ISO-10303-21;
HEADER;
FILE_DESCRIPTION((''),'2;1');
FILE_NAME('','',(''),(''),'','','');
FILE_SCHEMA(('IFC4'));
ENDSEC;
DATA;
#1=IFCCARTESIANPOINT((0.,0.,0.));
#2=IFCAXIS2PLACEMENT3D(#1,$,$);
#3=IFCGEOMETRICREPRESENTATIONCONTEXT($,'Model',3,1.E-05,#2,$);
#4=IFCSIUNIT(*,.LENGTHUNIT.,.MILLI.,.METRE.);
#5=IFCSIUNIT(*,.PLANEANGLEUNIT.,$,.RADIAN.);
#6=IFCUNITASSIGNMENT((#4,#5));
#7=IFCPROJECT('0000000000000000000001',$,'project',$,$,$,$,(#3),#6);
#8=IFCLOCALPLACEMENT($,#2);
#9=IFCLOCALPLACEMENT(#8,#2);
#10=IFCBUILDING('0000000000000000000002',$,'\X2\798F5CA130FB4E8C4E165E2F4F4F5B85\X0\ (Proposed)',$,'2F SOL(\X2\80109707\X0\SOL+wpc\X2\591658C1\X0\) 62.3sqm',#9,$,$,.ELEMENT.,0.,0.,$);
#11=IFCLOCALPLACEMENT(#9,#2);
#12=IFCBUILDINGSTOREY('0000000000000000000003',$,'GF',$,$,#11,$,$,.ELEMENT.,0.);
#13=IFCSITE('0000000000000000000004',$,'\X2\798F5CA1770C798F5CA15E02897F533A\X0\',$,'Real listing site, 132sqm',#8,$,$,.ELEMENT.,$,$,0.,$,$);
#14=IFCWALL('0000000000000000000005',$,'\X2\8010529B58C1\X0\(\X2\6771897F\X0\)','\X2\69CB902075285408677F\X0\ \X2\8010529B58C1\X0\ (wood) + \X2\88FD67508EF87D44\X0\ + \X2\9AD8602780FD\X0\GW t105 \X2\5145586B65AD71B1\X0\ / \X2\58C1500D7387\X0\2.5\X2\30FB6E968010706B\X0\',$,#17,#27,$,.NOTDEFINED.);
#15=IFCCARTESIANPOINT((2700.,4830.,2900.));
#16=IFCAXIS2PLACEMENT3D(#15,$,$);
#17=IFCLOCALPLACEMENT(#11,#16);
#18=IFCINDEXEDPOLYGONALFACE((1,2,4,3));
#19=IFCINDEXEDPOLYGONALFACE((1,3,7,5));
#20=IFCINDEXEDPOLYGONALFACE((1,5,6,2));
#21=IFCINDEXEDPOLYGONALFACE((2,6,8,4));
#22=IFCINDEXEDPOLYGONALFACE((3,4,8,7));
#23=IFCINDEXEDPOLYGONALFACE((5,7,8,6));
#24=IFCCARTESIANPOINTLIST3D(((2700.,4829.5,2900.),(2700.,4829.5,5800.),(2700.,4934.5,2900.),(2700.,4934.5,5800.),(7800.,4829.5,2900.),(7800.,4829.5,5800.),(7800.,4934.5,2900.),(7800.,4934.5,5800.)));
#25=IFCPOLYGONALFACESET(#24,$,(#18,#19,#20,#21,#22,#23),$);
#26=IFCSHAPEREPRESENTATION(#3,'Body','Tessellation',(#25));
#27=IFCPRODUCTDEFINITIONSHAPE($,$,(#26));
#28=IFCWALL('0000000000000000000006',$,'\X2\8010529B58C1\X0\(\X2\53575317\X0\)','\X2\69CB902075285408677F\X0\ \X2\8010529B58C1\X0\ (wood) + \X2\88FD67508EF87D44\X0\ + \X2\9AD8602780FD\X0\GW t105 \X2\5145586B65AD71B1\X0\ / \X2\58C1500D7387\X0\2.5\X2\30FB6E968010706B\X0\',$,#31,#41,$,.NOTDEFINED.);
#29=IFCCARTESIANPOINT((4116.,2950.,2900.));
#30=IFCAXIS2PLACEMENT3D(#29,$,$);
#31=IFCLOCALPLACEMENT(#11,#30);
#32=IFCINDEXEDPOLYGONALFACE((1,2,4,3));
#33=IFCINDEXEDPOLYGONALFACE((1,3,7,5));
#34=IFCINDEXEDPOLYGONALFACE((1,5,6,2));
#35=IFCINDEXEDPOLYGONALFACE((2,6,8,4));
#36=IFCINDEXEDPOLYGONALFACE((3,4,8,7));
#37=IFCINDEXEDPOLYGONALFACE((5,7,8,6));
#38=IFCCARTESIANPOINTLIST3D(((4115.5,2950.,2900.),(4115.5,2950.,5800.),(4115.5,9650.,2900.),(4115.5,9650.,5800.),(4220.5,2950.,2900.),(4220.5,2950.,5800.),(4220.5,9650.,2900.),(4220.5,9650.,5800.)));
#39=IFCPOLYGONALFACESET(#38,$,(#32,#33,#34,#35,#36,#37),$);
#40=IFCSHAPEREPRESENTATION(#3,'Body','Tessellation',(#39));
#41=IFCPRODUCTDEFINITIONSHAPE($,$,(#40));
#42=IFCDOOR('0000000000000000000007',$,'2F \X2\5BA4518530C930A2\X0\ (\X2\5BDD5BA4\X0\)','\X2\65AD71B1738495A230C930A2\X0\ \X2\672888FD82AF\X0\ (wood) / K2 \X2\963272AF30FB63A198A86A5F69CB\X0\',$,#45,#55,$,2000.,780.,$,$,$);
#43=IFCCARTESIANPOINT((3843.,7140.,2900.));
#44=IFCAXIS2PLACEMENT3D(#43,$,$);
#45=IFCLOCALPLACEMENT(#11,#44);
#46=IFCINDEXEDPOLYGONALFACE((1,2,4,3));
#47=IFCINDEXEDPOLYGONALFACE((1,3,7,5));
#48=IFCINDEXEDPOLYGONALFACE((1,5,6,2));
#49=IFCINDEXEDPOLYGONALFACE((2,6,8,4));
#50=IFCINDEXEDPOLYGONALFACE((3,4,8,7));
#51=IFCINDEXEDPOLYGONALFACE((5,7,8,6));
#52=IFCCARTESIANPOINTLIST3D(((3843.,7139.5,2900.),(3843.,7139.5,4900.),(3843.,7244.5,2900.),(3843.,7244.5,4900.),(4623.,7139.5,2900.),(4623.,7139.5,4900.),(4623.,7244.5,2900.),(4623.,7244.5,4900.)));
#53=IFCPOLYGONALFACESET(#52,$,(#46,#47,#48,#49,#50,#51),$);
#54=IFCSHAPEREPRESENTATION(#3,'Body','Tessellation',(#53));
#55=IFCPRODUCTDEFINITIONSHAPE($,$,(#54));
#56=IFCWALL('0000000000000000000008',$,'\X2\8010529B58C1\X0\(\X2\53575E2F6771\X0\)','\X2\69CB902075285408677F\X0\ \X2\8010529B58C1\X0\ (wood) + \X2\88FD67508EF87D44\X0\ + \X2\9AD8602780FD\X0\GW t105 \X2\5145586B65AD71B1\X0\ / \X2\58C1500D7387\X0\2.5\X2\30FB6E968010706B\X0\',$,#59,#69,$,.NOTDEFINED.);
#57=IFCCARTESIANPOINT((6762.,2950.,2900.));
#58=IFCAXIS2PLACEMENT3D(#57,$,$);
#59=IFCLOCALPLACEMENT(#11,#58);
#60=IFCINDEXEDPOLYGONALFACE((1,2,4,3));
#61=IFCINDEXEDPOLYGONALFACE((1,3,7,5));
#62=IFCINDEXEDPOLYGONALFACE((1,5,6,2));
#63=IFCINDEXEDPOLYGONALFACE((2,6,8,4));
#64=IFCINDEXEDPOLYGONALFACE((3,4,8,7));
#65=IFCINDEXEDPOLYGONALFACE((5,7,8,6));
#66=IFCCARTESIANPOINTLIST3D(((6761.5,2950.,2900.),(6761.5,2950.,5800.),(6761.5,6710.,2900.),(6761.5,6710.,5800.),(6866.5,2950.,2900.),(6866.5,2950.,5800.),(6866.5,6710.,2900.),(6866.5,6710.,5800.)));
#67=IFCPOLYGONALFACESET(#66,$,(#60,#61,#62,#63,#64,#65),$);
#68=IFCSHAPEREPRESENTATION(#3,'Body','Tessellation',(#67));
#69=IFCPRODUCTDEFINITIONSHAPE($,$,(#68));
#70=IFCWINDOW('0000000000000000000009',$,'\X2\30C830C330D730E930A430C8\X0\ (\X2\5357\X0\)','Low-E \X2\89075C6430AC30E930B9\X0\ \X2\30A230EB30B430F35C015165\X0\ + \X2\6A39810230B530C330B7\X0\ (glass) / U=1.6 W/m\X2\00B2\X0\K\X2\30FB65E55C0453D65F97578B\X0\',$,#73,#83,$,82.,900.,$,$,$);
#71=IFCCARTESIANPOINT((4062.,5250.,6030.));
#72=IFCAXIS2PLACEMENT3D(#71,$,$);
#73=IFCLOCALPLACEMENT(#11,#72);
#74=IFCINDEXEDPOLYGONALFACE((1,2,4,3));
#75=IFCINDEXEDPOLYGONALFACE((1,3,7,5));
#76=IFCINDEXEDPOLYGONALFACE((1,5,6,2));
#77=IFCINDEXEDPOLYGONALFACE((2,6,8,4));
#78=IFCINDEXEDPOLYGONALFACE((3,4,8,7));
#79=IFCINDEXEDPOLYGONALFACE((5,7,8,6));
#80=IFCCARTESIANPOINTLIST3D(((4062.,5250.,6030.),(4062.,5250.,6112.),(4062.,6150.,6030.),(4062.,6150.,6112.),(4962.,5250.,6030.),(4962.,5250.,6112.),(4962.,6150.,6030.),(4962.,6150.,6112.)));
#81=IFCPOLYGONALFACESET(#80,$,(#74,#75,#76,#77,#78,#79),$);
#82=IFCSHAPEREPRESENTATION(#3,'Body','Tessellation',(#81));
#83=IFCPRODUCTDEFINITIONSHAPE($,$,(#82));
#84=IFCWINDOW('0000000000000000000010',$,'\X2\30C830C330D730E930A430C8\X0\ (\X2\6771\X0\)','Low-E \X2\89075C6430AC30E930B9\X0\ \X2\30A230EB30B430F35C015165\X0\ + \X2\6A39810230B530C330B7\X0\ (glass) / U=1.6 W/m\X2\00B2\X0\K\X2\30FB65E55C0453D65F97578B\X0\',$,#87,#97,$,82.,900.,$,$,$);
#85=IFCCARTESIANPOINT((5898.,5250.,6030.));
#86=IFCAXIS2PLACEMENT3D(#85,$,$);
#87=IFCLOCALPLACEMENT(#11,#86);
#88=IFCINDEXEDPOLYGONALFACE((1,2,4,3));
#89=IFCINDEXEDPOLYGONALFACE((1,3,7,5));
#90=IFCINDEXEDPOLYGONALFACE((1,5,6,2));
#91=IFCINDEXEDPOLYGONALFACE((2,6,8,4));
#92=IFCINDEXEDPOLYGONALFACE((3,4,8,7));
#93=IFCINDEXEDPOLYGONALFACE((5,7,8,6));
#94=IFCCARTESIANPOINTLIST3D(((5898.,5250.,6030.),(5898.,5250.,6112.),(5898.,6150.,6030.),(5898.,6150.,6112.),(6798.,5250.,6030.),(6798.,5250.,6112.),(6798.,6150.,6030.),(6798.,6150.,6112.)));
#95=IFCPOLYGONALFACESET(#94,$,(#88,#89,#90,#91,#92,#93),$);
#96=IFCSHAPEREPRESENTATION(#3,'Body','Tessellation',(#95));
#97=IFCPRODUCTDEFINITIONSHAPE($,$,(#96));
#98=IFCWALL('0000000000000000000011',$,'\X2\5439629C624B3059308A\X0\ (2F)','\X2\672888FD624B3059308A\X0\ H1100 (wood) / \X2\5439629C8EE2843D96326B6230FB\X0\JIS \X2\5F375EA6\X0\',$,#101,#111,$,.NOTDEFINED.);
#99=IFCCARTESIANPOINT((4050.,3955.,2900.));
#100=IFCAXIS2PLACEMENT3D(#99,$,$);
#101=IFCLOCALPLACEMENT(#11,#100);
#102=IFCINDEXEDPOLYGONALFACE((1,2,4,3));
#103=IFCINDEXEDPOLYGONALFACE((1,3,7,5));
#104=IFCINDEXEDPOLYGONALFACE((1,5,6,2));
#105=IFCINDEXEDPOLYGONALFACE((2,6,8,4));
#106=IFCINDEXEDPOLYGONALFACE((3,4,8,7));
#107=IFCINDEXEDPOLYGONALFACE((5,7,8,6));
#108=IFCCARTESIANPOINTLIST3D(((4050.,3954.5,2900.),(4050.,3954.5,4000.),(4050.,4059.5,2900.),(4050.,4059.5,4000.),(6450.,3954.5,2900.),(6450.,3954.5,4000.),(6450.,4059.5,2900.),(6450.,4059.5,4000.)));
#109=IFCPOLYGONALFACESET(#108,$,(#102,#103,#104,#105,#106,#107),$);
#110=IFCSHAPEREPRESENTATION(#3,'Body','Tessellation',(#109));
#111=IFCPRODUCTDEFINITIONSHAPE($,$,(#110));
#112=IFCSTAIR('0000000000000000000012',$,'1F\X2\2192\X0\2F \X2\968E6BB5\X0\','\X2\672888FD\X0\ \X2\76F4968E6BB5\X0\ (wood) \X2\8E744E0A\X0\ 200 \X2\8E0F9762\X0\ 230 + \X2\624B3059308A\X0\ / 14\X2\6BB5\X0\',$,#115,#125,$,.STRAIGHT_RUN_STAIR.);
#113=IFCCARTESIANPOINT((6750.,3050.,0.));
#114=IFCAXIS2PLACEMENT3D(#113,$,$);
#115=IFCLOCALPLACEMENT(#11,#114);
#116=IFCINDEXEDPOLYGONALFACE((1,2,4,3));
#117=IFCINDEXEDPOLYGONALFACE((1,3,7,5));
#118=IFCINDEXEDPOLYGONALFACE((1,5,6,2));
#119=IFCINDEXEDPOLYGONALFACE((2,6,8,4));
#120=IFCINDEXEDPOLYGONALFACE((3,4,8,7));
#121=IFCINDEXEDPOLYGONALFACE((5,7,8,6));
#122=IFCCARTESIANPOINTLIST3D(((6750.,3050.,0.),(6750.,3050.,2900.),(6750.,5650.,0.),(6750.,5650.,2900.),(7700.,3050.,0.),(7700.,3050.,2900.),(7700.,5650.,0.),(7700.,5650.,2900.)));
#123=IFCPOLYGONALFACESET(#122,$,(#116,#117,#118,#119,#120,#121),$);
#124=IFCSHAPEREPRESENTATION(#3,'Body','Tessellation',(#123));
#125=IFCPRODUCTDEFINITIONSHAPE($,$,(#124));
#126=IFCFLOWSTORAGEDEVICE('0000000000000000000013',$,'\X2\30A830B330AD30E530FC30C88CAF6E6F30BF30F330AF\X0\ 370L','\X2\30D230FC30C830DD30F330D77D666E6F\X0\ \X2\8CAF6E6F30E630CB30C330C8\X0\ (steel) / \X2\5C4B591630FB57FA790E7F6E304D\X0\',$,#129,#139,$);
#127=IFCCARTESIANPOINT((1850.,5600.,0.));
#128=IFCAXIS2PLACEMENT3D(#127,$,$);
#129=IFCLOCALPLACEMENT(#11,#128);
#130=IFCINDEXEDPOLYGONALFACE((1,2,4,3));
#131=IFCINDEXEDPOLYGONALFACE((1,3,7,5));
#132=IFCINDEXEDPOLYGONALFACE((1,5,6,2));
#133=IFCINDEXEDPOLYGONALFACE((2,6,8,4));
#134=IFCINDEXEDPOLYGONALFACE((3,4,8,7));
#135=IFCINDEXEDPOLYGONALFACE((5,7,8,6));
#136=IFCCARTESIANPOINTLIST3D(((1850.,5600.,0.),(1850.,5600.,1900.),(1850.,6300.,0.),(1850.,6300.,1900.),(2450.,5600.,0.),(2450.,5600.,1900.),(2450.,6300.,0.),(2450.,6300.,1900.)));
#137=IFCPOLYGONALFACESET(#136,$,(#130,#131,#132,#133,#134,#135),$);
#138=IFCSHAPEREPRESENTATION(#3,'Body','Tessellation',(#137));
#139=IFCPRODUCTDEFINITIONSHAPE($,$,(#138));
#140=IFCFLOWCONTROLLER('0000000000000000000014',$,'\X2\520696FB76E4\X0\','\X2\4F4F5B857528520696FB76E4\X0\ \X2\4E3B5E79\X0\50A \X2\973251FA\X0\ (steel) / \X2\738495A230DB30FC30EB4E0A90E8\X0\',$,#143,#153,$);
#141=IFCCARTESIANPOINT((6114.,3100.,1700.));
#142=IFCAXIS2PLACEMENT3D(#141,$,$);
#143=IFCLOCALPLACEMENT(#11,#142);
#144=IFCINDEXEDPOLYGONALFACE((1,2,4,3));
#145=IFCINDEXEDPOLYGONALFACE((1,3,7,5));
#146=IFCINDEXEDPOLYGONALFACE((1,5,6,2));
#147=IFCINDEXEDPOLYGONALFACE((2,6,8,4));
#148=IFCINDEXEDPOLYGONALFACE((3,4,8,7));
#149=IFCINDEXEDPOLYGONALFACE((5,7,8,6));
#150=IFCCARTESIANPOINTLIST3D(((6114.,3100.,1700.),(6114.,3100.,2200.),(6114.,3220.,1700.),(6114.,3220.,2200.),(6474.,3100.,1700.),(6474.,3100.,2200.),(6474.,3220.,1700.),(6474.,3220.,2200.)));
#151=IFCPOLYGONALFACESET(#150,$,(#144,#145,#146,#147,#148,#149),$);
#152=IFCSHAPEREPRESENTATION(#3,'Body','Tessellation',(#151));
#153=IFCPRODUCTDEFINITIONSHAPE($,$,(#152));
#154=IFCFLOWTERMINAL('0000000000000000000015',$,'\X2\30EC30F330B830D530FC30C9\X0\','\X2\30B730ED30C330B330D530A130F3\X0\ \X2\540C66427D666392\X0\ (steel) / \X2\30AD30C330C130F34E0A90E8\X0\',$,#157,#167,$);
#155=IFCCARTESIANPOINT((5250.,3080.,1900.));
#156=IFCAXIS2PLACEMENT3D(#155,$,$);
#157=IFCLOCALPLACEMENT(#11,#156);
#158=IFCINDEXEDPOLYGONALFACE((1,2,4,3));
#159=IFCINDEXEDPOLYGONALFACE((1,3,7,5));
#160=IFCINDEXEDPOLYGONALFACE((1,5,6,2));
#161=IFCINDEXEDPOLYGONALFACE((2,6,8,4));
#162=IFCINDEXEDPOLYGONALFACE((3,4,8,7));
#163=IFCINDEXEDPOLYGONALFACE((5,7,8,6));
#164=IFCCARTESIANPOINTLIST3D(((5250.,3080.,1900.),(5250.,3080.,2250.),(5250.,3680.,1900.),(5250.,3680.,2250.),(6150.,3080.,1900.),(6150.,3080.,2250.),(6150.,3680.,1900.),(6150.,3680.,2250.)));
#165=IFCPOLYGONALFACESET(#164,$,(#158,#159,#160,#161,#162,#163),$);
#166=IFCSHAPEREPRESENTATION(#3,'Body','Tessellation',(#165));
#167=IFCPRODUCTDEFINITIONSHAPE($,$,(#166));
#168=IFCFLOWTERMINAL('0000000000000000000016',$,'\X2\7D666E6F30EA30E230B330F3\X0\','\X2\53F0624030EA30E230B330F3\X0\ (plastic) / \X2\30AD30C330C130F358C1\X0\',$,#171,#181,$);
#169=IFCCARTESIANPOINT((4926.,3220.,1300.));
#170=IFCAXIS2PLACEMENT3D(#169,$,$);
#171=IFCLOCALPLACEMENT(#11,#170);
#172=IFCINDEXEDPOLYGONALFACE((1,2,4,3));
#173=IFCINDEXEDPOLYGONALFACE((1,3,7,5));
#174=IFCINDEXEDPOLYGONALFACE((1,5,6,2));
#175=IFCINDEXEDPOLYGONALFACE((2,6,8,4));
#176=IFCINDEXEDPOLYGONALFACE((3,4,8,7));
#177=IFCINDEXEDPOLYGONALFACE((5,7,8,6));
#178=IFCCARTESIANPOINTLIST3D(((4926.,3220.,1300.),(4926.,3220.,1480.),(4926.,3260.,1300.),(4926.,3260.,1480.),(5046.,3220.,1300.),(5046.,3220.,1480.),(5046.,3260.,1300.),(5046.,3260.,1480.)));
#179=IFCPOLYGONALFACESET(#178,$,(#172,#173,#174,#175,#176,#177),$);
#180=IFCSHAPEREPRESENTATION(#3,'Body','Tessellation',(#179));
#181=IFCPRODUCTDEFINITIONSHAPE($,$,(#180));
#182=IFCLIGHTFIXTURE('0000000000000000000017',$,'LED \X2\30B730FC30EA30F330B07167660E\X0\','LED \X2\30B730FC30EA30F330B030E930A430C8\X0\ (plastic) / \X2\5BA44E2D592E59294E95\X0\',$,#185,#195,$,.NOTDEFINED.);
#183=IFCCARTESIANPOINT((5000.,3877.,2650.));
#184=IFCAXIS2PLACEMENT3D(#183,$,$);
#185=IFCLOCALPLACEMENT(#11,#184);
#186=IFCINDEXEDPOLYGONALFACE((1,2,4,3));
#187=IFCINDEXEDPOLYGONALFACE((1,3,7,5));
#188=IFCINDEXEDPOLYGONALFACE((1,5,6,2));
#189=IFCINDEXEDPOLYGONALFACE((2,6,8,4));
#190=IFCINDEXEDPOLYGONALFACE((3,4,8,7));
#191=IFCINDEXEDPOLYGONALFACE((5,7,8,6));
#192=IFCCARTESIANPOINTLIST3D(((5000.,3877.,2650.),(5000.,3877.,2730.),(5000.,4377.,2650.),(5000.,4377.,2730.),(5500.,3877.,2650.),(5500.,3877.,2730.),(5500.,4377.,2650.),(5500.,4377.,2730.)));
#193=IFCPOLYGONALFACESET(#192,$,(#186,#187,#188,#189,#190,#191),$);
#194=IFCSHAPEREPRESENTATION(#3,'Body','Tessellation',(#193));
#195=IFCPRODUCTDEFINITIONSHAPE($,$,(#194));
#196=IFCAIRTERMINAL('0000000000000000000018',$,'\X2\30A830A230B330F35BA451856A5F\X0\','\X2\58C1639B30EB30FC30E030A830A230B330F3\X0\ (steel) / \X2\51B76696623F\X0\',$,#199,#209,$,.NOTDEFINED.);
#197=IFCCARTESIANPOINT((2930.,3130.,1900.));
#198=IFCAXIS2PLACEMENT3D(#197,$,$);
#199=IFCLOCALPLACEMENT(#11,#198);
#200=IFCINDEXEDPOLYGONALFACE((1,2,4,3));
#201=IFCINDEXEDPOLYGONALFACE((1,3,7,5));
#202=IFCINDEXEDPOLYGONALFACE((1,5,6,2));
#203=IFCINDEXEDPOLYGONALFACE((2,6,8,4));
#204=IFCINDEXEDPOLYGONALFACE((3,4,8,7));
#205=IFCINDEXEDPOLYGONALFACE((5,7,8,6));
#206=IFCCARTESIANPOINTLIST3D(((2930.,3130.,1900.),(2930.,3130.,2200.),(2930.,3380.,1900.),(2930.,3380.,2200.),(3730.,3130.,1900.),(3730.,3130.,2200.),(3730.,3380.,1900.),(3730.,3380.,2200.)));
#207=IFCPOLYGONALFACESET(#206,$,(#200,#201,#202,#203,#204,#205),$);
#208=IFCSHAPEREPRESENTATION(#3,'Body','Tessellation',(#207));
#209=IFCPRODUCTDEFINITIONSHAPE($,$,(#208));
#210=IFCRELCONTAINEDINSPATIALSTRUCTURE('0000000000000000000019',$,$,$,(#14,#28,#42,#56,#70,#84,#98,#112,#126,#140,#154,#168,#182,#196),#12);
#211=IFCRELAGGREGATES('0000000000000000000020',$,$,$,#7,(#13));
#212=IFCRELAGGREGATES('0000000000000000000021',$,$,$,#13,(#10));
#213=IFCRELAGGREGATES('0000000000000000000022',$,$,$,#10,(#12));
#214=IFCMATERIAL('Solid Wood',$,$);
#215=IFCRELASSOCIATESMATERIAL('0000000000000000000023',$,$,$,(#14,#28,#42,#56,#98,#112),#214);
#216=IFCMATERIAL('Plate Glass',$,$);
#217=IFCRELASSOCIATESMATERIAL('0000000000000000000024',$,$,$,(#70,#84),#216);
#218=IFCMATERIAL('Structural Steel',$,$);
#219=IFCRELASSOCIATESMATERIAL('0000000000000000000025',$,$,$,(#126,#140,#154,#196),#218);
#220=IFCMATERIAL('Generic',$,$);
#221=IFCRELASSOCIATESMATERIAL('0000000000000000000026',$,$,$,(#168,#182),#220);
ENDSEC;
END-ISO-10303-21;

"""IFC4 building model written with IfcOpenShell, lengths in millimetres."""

from ifc_helpers import new_model, si_unit, frame, frame_2d, origin, place, context, project, spatial, rectangle, extrude, material, element, fill, save


model = new_model("IFC4")

# Units and contexts
model_context = context("Model", 3, precision=1e-05, world=origin())
ifc_project = project(units=[si_unit("LENGTHUNIT", "METRE", prefix="MILLI"), si_unit("PLANEANGLEUNIT", "RADIAN")], contexts=[model_context])

# Site, building, storey
site_placement = place(None, origin())
site = spatial("IfcSite", under=ifc_project, at=site_placement, Name="福岡県福岡市西区", ObjectType="Real listing site, 132sqm", CompositionType="ELEMENT", RefElevation=0.0)
building_placement = place(site_placement, origin())
building = spatial("IfcBuilding", under=site, at=building_placement, Name="福岡・二世帯住宅 (Proposed)", ObjectType="2F SOL(耐震SOL+wpc外壁) 62.3sqm", CompositionType="ELEMENT", ElevationOfRefHeight=0.0, ElevationOfTerrain=0.0)
storey_placement = place(building_placement, origin())
storey = spatial("IfcBuildingStorey", under=building, at=storey_placement, Name="GF", CompositionType="ELEMENT", Elevation=0.0)

# Shared definitions
ifc_material_1 = material(Name="Solid Wood")

# Wall
wall_1_placement = place(storey_placement, frame((2700.0, 4830.0, 2900.0)))
element("IfcWall", 1, at=wall_1_placement, inside=storey, material=ifc_material_1, Name="耐力壁(東西)", Description="構造用合板 耐力壁 (wood) + 製材軸組 + 高性能GW t105 充填断熱 / 壁倍率2.5・準耐火", PredefinedType="NOTDEFINED", context=model_context, shape_type="SweptSolid", body=[
    extrude(rectangle(XDim=5100.0, YDim=105.0, at=frame_2d((2550.0, 52.0))), frame((2700.0, 4830.0, 2900.0)), (0.0, 0.0, 1.0), 2900.0),
])

# Wall, opening, door
wall_2_placement = place(storey_placement, frame((4116.0, 2950.0, 2900.0)))
wall_2 = element("IfcWall", 2, at=wall_2_placement, inside=storey, material=ifc_material_1, Name="耐力壁(南北)", Description="構造用合板 耐力壁 (wood) + 製材軸組 + 高性能GW t105 充填断熱 / 壁倍率2.5・準耐火", PredefinedType="NOTDEFINED", context=model_context, shape_type="SweptSolid", body=[
    extrude(rectangle(XDim=105.0, YDim=6700.0, at=frame_2d((52.0, 3350.0))), frame((4116.0, 2950.0, 2900.0)), (0.0, 0.0, 1.0), 2900.0),
])
opening_placement = place(storey_placement, frame((3843.0, 7140.0, 2900.0)))
opening = element("IfcOpeningElement", 3, at=opening_placement, cuts=wall_2, PredefinedType="NOTDEFINED", context=model_context, shape_type="SweptSolid", body=[
    extrude(rectangle(XDim=780.0, YDim=105.0, at=frame_2d((390.0, 52.0))), frame((3843.0, 7140.0, 2900.0)), (0.0, 0.0, 1.0), 2000.0),
])
door_placement = place(storey_placement, frame((3843.0, 7140.0, 2900.0)))
door = element("IfcDoor", 4, at=door_placement, inside=storey, material=ifc_material_1, Name="2F 室内ドア (寝室)", Description="断熱玄関ドア 木製芯 (wood) / K2 防犯・採風機構", OverallHeight=2000.0, OverallWidth=780.0, context=model_context, shape_type="SweptSolid", body=[
    extrude(rectangle(XDim=780.0, YDim=105.0, at=frame_2d((390.0, 52.0))), frame((3843.0, 7140.0, 2900.0)), (0.0, 0.0, 1.0), 2000.0),
])
fill(opening, door)

# Wall
wall_3_placement = place(storey_placement, frame((6762.0, 2950.0, 2900.0)))
element("IfcWall", 5, at=wall_3_placement, inside=storey, material=ifc_material_1, Name="耐力壁(南帯東)", Description="構造用合板 耐力壁 (wood) + 製材軸組 + 高性能GW t105 充填断熱 / 壁倍率2.5・準耐火", PredefinedType="NOTDEFINED", context=model_context, shape_type="SweptSolid", body=[
    extrude(rectangle(XDim=105.0, YDim=3760.0, at=frame_2d((52.0, 1880.0))), frame((6762.0, 2950.0, 2900.0)), (0.0, 0.0, 1.0), 2900.0),
])

# Windows
ifc_material_2 = material(Name="Plate Glass")
window_1_placement = place(storey_placement, frame((4062.0, 5250.0, 6030.0)))
element("IfcWindow", 6, at=window_1_placement, inside=storey, material=ifc_material_2, Name="トップライト (南)", Description="Low-E 複層ガラス アルゴン封入 + 樹脂サッシ (glass) / U=1.6 W/m²K・日射取得型", OverallHeight=82.0, OverallWidth=900.0, context=model_context, shape_type="SweptSolid", body=[
    extrude(rectangle(XDim=900.0, YDim=900.0, at=frame_2d((450.0, 450.0))), frame((4062.0, 5250.0, 6030.0)), (0.0, 0.0, 1.0), 82.0),
])
window_2_placement = place(storey_placement, frame((5898.0, 5250.0, 6030.0)))
element("IfcWindow", 7, at=window_2_placement, inside=storey, material=ifc_material_2, Name="トップライト (東)", Description="Low-E 複層ガラス アルゴン封入 + 樹脂サッシ (glass) / U=1.6 W/m²K・日射取得型", OverallHeight=82.0, OverallWidth=900.0, context=model_context, shape_type="SweptSolid", body=[
    extrude(rectangle(XDim=900.0, YDim=900.0, at=frame_2d((450.0, 450.0))), frame((5898.0, 5250.0, 6030.0)), (0.0, 0.0, 1.0), 82.0),
])

# Wall
wall_4_placement = place(storey_placement, frame((4050.0, 3955.0, 2900.0)))
element("IfcWall", 8, at=wall_4_placement, inside=storey, material=ifc_material_1, Name="吹抜手すり (2F)", Description="木製手すり H1100 (wood) / 吹抜転落防止・JIS 強度", PredefinedType="NOTDEFINED", context=model_context, shape_type="SweptSolid", body=[
    extrude(rectangle(XDim=2400.0, YDim=105.0, at=frame_2d((1200.0, 52.0))), frame((4050.0, 3955.0, 2900.0)), (0.0, 0.0, 1.0), 1100.0),
])

# Stair
stair_placement = place(storey_placement, frame((6750.0, 3050.0, 0.0)))
element("IfcStair", 9, at=stair_placement, inside=storey, material=ifc_material_1, Name="1F→2F 階段", Description="木製 直階段 (wood) 蹴上 200 踏面 230 + 手すり / 14段", PredefinedType="STRAIGHT_RUN_STAIR", context=model_context, shape_type="SweptSolid", body=[
    extrude(rectangle(XDim=950.0, YDim=2600.0, at=frame_2d((475.0, 1300.0))), frame((6750.0, 3050.0, 0.0)), (0.0, 0.0, 1.0), 2900.0),
])

# Flow storage device
ifc_material_3 = material(Name="Structural Steel")
flow_storage_device_placement = place(storey_placement, frame((1850.0, 5600.0, 0.0)))
element("IfcFlowStorageDevice", 10, at=flow_storage_device_placement, inside=storey, material=ifc_material_3, Name="エコキュート貯湯タンク 370L", Description="ヒートポンプ給湯 貯湯ユニット (steel) / 屋外・基礎置き", context=model_context, shape_type="SweptSolid", body=[
    extrude(rectangle(XDim=600.0, YDim=700.0, at=frame_2d((300.0, 350.0))), frame((1850.0, 5600.0, 0.0)), (0.0, 0.0, 1.0), 1900.0),
])

# Flow controller
flow_controller_placement = place(storey_placement, frame((6114.0, 3100.0, 1700.0)))
element("IfcFlowController", 11, at=flow_controller_placement, inside=storey, material=ifc_material_3, Name="分電盤", Description="住宅用分電盤 主幹50A 露出 (steel) / 玄関ホール上部", context=model_context, shape_type="SweptSolid", body=[
    extrude(rectangle(XDim=360.0, YDim=120.0, at=frame_2d((180.0, 60.0))), frame((6114.0, 3100.0, 1700.0)), (0.0, 0.0, 1.0), 500.0),
])

# Flow terminals
flow_terminal_1_placement = place(storey_placement, frame((5250.0, 3080.0, 1900.0)))
element("IfcFlowTerminal", 12, at=flow_terminal_1_placement, inside=storey, material=ifc_material_3, Name="レンジフード", Description="シロッコファン 同時給排 (steel) / キッチン上部", context=model_context, shape_type="SweptSolid", body=[
    extrude(rectangle(XDim=900.0, YDim=600.0, at=frame_2d((450.0, 300.0))), frame((5250.0, 3080.0, 1900.0)), (0.0, 0.0, 1.0), 350.0),
])
ifc_material_4 = material(Name="Generic")
flow_terminal_2_placement = place(storey_placement, frame((4926.0, 3220.0, 1300.0)))
element("IfcFlowTerminal", 13, at=flow_terminal_2_placement, inside=storey, material=ifc_material_4, Name="給湯リモコン", Description="台所リモコン (plastic) / キッチン壁", context=model_context, shape_type="SweptSolid", body=[
    extrude(rectangle(XDim=120.0, YDim=40.0, at=frame_2d((60.0, 20.0))), frame((4926.0, 3220.0, 1300.0)), (0.0, 0.0, 1.0), 180.0),
])

# Light fixture
light_fixture_1_placement = place(storey_placement, frame((5000.0, 3877.0, 2650.0)))
element("IfcLightFixture", 14, at=light_fixture_1_placement, inside=storey, material=ifc_material_4, Name="LED シーリング照明", Description="LED シーリングライト (plastic) / 室中央天井", PredefinedType="NOTDEFINED", context=model_context, shape_type="SweptSolid", body=[
    extrude(rectangle(XDim=500.0, YDim=500.0, at=frame_2d((250.0, 250.0))), frame((5000.0, 3877.0, 2650.0)), (0.0, 0.0, 1.0), 80.0),
])

# Air terminal
air_terminal_1_placement = place(storey_placement, frame((2930.0, 3130.0, 1900.0)))
element("IfcAirTerminal", 15, at=air_terminal_1_placement, inside=storey, material=ifc_material_3, Name="エアコン室内機", Description="壁掛ルームエアコン (steel) / 冷暖房", PredefinedType="NOTDEFINED", context=model_context, shape_type="SweptSolid", body=[
    extrude(rectangle(XDim=800.0, YDim=250.0, at=frame_2d((400.0, 125.0))), frame((2930.0, 3130.0, 1900.0)), (0.0, 0.0, 1.0), 300.0),
])

save(model, "model.ifc")
